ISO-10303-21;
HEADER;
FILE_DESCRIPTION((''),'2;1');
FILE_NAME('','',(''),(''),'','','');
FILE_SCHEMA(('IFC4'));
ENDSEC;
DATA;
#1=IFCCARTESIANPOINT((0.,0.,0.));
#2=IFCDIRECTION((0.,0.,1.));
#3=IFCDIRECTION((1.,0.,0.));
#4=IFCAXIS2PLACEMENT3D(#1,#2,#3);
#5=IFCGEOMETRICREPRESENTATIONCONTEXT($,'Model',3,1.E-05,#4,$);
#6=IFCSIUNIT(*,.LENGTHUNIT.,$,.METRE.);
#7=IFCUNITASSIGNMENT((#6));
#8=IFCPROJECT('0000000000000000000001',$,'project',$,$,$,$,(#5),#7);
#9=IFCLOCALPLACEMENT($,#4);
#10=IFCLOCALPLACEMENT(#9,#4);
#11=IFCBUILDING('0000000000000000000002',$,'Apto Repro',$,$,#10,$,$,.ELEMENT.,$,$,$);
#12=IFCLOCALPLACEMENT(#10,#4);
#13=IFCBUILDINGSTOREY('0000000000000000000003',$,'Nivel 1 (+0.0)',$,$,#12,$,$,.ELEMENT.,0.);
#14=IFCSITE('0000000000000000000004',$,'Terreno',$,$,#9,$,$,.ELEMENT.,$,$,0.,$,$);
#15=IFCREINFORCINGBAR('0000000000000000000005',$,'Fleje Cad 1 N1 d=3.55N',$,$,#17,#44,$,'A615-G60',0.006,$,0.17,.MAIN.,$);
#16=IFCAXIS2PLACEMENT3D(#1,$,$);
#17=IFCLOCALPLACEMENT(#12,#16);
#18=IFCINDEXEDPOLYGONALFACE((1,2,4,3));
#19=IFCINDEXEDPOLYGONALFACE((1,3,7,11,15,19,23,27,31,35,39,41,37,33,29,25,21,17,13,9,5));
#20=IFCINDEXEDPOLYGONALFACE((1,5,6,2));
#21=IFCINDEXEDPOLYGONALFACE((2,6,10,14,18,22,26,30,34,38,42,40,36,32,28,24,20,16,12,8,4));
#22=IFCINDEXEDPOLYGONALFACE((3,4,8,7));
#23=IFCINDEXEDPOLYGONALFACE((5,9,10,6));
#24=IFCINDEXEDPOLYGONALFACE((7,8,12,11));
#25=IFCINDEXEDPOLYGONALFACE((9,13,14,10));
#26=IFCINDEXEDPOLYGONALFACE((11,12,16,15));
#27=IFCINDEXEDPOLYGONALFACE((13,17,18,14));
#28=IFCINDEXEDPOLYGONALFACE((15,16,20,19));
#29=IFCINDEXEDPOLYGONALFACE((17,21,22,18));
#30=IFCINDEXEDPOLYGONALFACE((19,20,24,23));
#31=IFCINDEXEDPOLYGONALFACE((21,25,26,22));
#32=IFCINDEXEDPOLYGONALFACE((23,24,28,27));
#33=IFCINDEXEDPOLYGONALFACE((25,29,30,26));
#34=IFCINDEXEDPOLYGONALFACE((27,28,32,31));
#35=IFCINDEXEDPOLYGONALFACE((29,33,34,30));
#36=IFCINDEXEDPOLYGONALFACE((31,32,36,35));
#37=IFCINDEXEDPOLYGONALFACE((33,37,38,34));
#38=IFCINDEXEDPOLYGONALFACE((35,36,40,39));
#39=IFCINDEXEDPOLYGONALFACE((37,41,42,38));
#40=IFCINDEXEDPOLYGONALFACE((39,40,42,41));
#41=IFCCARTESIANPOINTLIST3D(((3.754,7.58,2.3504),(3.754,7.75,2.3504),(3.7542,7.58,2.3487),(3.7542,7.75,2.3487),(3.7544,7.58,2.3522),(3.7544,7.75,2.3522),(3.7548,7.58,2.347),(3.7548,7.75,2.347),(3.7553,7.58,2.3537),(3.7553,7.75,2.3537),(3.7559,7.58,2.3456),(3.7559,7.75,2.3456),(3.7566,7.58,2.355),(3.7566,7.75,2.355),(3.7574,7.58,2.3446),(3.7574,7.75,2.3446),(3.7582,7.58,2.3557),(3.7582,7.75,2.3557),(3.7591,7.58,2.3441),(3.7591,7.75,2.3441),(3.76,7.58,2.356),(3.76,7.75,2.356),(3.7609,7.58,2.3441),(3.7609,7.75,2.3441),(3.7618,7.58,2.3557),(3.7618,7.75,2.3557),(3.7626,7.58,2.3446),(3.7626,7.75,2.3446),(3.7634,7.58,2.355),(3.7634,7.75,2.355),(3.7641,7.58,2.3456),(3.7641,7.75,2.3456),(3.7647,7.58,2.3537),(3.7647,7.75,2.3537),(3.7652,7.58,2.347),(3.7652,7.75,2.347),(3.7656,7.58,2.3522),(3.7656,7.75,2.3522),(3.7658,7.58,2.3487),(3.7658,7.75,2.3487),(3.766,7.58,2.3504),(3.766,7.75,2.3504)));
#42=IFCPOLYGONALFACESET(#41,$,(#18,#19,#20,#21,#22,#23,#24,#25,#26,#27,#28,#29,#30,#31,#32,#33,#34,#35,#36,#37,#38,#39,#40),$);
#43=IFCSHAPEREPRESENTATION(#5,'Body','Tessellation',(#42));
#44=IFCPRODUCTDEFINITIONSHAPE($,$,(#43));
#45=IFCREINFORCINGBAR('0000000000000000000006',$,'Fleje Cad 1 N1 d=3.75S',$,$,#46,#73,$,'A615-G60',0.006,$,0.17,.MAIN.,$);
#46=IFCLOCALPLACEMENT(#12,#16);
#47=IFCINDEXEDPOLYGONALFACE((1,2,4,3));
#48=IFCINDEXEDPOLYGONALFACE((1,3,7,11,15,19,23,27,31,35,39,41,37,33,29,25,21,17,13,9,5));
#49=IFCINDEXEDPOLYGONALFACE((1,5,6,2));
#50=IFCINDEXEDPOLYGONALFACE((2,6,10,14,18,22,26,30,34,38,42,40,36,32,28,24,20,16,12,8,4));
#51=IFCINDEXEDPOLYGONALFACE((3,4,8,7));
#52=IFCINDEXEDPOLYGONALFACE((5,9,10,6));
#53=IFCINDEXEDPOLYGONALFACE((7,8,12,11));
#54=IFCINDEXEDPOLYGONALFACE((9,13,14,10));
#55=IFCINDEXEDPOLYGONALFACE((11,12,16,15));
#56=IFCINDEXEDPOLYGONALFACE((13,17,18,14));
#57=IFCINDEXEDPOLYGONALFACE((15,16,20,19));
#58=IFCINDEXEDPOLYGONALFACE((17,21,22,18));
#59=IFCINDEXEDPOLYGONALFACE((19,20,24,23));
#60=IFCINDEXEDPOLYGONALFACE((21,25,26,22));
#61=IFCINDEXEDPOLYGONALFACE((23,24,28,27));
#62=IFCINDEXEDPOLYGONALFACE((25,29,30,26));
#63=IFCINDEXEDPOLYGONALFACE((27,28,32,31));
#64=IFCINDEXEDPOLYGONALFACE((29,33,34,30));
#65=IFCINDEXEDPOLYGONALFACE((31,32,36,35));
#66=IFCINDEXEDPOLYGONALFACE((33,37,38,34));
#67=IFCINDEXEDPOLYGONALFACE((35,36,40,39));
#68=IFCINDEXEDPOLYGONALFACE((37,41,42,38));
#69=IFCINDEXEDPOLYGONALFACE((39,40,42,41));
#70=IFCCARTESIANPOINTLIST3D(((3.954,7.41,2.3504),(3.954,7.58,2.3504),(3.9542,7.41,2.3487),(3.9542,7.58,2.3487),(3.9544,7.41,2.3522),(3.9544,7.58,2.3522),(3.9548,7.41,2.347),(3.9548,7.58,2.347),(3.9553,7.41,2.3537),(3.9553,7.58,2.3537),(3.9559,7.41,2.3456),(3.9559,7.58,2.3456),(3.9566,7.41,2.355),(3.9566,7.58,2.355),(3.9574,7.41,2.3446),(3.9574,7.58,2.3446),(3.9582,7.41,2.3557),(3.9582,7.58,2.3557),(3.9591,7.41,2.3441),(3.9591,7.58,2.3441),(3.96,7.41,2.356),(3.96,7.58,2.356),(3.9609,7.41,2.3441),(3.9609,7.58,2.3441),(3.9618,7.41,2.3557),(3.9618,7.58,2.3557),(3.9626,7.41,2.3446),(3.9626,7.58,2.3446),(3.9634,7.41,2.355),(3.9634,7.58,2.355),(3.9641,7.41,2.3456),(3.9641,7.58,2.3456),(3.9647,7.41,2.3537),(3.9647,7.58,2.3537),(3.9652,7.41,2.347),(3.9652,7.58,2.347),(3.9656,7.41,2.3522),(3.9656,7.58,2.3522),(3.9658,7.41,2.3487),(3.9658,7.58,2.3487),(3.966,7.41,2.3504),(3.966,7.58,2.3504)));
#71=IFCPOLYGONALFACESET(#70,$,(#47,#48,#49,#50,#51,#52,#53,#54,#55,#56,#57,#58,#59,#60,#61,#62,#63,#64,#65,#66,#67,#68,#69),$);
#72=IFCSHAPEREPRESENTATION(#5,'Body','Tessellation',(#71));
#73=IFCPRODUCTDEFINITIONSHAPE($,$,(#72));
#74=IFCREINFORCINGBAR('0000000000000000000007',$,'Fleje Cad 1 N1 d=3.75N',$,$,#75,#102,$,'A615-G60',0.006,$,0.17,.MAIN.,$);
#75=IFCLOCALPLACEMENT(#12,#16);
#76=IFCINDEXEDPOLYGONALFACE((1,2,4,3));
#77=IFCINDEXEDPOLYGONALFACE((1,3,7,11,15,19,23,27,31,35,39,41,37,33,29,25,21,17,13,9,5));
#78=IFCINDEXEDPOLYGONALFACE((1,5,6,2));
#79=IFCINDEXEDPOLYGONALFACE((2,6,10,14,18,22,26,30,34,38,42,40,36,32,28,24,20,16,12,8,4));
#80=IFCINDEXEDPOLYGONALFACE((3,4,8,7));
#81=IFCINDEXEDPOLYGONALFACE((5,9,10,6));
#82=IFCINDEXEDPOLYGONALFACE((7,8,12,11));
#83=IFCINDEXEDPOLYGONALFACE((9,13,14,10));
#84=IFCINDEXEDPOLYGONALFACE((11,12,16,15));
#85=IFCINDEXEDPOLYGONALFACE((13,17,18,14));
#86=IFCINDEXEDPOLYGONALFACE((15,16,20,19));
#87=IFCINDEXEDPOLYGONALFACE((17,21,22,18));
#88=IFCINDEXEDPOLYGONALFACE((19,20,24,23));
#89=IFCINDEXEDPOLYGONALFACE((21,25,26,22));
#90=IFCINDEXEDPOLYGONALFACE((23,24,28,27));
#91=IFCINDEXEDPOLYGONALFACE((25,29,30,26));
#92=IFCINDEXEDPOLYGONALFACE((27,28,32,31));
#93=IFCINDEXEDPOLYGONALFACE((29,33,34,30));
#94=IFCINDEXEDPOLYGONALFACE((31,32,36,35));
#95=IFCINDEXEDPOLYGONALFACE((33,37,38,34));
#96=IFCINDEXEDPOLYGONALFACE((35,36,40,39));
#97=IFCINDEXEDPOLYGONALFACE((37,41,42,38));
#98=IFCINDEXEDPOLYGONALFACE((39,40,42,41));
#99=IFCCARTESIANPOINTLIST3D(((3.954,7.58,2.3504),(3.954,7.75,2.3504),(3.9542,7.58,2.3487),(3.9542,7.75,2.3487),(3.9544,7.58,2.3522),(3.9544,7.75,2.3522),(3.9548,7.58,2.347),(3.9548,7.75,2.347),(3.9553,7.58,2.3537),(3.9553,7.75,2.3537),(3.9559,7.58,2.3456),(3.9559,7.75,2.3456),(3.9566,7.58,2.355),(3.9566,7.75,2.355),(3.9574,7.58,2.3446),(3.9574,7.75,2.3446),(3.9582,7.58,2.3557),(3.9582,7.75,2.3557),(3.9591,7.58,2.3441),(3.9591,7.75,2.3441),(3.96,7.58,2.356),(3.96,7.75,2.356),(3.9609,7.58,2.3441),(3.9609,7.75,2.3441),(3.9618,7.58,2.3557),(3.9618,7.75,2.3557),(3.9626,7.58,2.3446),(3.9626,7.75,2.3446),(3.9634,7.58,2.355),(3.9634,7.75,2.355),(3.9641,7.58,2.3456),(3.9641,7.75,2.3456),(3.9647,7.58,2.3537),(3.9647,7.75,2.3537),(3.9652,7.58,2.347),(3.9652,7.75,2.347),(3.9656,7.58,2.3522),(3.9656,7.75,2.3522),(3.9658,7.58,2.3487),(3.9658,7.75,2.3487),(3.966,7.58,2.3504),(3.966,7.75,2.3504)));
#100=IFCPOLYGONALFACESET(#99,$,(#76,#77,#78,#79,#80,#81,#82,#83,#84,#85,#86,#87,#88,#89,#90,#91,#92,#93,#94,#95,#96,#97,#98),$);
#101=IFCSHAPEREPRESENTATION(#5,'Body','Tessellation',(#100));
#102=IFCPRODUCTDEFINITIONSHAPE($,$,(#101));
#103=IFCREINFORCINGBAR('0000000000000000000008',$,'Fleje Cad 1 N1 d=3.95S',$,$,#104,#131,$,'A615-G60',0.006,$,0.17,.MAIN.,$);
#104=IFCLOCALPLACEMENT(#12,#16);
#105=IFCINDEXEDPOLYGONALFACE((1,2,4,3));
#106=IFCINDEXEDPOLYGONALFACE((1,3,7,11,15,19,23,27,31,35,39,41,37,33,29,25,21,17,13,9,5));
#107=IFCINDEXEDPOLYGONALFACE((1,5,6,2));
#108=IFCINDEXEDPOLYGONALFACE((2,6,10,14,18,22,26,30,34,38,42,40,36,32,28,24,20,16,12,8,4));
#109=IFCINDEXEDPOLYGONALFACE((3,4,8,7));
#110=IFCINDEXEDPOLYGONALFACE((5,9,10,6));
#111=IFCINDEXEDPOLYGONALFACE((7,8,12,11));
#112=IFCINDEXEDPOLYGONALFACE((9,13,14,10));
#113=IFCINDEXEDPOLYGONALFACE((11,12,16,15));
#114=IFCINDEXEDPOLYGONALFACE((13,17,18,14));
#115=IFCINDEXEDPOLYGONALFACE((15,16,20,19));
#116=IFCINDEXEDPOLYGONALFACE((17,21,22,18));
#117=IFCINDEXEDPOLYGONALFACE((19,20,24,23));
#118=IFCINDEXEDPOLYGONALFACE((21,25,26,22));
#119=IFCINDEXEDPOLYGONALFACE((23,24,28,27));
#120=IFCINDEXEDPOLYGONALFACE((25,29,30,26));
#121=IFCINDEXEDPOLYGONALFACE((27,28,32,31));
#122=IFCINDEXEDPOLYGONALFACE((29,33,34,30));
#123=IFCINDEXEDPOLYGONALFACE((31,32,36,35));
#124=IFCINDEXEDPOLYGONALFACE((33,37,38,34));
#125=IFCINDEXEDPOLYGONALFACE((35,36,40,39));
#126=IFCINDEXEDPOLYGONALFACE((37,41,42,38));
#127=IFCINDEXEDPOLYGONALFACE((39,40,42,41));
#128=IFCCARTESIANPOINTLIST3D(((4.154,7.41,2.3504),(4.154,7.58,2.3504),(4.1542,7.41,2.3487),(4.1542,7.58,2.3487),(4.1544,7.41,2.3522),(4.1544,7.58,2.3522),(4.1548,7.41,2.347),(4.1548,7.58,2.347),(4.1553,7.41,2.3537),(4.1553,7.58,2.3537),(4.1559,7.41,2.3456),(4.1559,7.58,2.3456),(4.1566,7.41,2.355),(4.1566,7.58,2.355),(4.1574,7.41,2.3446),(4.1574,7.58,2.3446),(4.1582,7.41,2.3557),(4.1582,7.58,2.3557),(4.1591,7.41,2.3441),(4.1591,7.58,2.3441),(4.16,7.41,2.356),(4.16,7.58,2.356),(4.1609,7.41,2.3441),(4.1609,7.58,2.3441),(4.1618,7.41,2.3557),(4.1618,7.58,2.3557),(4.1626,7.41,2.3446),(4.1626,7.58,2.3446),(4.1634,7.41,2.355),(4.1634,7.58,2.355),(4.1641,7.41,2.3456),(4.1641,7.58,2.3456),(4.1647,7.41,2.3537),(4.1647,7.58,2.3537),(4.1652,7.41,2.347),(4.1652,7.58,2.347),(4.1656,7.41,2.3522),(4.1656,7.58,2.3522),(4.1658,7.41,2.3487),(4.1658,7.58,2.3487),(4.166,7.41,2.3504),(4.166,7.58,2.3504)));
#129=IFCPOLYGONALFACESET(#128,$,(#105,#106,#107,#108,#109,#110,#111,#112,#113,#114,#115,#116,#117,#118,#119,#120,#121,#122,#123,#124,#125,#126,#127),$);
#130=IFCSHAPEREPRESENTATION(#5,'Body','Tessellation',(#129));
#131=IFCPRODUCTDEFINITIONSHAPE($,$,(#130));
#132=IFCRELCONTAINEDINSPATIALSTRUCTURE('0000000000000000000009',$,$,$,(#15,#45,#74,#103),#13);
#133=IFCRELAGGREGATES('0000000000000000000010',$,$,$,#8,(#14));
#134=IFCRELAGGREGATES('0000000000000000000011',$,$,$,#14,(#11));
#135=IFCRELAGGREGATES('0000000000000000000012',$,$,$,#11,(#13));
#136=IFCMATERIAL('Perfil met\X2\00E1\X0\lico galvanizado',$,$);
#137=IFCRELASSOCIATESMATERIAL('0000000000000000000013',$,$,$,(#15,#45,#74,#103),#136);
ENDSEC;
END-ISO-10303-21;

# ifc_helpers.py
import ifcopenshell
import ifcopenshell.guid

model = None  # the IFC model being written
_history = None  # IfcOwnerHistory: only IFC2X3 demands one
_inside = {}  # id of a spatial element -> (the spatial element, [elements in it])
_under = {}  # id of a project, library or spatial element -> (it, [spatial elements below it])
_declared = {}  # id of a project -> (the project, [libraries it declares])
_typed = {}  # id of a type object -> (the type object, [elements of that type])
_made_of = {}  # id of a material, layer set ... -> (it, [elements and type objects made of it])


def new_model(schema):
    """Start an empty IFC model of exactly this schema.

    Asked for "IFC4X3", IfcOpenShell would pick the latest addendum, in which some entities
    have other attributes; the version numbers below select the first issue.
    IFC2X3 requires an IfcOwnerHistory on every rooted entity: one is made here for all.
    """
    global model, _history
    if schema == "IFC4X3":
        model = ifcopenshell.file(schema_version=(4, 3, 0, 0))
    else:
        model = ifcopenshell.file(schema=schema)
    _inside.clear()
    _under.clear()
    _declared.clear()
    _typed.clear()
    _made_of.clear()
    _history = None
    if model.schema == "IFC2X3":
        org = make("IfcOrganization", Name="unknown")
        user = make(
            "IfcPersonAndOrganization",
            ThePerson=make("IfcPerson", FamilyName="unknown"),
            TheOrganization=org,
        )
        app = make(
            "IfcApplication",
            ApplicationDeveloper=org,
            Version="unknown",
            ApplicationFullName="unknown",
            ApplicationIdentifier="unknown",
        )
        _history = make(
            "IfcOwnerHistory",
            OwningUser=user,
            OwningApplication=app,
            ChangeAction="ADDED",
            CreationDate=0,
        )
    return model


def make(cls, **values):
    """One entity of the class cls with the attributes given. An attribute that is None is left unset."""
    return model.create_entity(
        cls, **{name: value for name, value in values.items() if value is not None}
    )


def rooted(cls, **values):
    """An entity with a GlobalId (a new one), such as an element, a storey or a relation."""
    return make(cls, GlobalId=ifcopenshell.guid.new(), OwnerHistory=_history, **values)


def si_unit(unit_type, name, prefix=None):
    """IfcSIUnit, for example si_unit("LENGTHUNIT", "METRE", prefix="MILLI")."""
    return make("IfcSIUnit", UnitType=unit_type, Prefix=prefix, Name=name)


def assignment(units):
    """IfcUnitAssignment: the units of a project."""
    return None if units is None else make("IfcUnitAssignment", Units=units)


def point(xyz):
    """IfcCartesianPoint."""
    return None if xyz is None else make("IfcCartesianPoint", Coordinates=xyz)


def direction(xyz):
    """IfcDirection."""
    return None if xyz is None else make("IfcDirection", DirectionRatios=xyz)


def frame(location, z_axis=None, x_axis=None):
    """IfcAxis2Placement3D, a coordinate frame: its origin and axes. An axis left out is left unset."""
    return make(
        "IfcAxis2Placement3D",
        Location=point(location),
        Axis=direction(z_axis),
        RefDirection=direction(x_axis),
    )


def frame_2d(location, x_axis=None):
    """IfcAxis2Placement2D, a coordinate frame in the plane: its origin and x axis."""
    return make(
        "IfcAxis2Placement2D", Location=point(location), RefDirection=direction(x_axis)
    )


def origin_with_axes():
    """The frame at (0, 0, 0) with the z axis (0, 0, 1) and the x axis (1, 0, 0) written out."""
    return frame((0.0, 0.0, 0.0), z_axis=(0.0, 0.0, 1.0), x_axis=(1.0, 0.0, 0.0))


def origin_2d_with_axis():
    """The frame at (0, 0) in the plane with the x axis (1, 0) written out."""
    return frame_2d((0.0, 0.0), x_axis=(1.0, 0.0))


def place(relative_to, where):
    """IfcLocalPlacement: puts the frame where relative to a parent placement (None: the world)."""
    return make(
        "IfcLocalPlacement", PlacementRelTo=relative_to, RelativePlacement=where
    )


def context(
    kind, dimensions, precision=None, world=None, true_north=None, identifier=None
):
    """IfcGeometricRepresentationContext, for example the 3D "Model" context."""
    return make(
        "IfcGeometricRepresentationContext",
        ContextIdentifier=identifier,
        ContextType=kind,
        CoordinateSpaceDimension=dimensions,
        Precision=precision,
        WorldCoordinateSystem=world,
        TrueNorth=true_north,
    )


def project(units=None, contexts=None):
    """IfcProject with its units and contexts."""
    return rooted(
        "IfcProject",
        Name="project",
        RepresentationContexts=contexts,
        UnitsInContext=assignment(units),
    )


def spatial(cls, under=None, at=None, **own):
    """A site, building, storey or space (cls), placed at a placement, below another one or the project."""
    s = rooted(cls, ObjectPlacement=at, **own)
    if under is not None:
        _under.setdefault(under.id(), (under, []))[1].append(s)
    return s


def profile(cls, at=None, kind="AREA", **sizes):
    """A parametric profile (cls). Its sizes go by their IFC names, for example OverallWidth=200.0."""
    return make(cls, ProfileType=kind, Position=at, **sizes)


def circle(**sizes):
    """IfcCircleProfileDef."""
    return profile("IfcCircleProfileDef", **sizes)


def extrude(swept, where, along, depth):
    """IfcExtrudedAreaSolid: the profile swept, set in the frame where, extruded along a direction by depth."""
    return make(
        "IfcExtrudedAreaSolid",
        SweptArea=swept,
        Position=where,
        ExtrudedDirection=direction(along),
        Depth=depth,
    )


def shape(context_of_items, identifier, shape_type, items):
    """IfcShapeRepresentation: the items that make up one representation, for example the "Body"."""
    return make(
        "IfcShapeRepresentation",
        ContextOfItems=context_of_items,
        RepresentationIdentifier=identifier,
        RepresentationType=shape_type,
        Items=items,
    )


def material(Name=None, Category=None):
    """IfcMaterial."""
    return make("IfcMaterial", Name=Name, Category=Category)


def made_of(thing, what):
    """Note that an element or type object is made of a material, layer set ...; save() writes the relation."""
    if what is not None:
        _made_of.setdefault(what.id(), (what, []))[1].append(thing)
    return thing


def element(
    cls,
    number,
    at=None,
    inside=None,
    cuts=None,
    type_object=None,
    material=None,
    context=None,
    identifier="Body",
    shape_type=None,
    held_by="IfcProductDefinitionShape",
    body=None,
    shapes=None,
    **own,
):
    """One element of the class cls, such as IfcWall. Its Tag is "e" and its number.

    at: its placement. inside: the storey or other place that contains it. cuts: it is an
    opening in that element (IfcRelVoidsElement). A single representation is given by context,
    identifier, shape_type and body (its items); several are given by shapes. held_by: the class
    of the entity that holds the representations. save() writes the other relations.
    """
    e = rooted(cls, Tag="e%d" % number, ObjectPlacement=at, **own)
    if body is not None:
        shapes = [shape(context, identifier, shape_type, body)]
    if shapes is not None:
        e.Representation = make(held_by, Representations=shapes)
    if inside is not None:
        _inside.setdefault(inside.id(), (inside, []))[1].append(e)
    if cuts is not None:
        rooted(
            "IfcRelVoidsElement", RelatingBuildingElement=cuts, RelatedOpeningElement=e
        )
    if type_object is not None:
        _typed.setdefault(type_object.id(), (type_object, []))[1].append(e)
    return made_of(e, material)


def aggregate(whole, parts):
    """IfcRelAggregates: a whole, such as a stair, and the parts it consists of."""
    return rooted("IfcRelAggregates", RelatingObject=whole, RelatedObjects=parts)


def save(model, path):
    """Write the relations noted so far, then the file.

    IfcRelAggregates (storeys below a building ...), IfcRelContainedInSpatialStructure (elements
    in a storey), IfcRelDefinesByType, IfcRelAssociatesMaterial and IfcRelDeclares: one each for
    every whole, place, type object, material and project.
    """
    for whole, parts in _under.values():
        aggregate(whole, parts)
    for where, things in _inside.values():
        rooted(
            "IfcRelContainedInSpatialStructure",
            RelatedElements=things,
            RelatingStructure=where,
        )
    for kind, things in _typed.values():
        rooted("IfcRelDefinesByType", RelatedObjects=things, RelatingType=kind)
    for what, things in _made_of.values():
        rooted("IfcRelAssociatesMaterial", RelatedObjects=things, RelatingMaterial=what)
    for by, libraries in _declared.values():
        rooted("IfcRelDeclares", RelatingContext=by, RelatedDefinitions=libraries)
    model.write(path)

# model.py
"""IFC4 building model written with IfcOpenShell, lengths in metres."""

from ifc_helpers import new_model, si_unit, frame, origin_with_axes, origin_2d_with_axis, place, context, project, spatial, circle, extrude, material, element, save


model = new_model("IFC4")

# Units and contexts
model_context = context("Model", 3, precision=1e-05, world=origin_with_axes())
ifc_project = project(units=[si_unit("LENGTHUNIT", "METRE")], contexts=[model_context])

# Site, building, storey
site_placement = place(None, origin_with_axes())
site = spatial("IfcSite", under=ifc_project, at=site_placement, Name="Terreno", CompositionType="ELEMENT", RefElevation=0.0)
building_placement = place(site_placement, origin_with_axes())
building = spatial("IfcBuilding", under=site, at=building_placement, Name="Apto Repro", CompositionType="ELEMENT")
storey_placement = place(building_placement, origin_with_axes())
storey = spatial("IfcBuildingStorey", under=building, at=storey_placement, Name="Nivel 1 (+0.0)", CompositionType="ELEMENT", Elevation=0.0)

# Reinforcing bars
ifc_material = material(Name="Perfil metálico galvanizado")
reinforcing_bar_1_placement = place(storey_placement, origin_with_axes())
element("IfcReinforcingBar", 1, at=reinforcing_bar_1_placement, inside=storey, material=ifc_material, Name="Fleje Cad 1 N1 d=3.55N", SteelGrade="A615-G60", BarLength=0.17, NominalDiameter=0.006, PredefinedType="MAIN", context=model_context, shape_type="SweptSolid", body=[
    extrude(circle(Radius=0.006, at=origin_2d_with_axis()), frame((3.76, 7.58, 2.35), z_axis=(0.0, 1.0, 0.0), x_axis=(0.0, 0.0, 1.0)), (0.0, 0.0, 1.0), 0.17),
])
reinforcing_bar_2_placement = place(storey_placement, origin_with_axes())
element("IfcReinforcingBar", 2, at=reinforcing_bar_2_placement, inside=storey, material=ifc_material, Name="Fleje Cad 1 N1 d=3.75S", SteelGrade="A615-G60", BarLength=0.17, NominalDiameter=0.006, PredefinedType="MAIN", context=model_context, shape_type="SweptSolid", body=[
    extrude(circle(Radius=0.006, at=origin_2d_with_axis()), frame((3.96, 7.41, 2.35), z_axis=(0.0, 1.0, 0.0), x_axis=(0.0, 0.0, 1.0)), (0.0, 0.0, 1.0), 0.17),
])
reinforcing_bar_3_placement = place(storey_placement, origin_with_axes())
element("IfcReinforcingBar", 3, at=reinforcing_bar_3_placement, inside=storey, material=ifc_material, Name="Fleje Cad 1 N1 d=3.75N", SteelGrade="A615-G60", BarLength=0.17, NominalDiameter=0.006, PredefinedType="MAIN", context=model_context, shape_type="SweptSolid", body=[
    extrude(circle(Radius=0.006, at=origin_2d_with_axis()), frame((3.96, 7.58, 2.35), z_axis=(0.0, 1.0, 0.0), x_axis=(0.0, 0.0, 1.0)), (0.0, 0.0, 1.0), 0.17),
])
reinforcing_bar_4_placement = place(storey_placement, origin_with_axes())
element("IfcReinforcingBar", 4, at=reinforcing_bar_4_placement, inside=storey, material=ifc_material, Name="Fleje Cad 1 N1 d=3.95S", SteelGrade="A615-G60", BarLength=0.17, NominalDiameter=0.006, PredefinedType="MAIN", context=model_context, shape_type="SweptSolid", body=[
    extrude(circle(Radius=0.006, at=origin_2d_with_axis()), frame((4.16, 7.41, 2.35), z_axis=(0.0, 1.0, 0.0), x_axis=(0.0, 0.0, 1.0)), (0.0, 0.0, 1.0), 0.17),
])

save(model, "model.ifc")
